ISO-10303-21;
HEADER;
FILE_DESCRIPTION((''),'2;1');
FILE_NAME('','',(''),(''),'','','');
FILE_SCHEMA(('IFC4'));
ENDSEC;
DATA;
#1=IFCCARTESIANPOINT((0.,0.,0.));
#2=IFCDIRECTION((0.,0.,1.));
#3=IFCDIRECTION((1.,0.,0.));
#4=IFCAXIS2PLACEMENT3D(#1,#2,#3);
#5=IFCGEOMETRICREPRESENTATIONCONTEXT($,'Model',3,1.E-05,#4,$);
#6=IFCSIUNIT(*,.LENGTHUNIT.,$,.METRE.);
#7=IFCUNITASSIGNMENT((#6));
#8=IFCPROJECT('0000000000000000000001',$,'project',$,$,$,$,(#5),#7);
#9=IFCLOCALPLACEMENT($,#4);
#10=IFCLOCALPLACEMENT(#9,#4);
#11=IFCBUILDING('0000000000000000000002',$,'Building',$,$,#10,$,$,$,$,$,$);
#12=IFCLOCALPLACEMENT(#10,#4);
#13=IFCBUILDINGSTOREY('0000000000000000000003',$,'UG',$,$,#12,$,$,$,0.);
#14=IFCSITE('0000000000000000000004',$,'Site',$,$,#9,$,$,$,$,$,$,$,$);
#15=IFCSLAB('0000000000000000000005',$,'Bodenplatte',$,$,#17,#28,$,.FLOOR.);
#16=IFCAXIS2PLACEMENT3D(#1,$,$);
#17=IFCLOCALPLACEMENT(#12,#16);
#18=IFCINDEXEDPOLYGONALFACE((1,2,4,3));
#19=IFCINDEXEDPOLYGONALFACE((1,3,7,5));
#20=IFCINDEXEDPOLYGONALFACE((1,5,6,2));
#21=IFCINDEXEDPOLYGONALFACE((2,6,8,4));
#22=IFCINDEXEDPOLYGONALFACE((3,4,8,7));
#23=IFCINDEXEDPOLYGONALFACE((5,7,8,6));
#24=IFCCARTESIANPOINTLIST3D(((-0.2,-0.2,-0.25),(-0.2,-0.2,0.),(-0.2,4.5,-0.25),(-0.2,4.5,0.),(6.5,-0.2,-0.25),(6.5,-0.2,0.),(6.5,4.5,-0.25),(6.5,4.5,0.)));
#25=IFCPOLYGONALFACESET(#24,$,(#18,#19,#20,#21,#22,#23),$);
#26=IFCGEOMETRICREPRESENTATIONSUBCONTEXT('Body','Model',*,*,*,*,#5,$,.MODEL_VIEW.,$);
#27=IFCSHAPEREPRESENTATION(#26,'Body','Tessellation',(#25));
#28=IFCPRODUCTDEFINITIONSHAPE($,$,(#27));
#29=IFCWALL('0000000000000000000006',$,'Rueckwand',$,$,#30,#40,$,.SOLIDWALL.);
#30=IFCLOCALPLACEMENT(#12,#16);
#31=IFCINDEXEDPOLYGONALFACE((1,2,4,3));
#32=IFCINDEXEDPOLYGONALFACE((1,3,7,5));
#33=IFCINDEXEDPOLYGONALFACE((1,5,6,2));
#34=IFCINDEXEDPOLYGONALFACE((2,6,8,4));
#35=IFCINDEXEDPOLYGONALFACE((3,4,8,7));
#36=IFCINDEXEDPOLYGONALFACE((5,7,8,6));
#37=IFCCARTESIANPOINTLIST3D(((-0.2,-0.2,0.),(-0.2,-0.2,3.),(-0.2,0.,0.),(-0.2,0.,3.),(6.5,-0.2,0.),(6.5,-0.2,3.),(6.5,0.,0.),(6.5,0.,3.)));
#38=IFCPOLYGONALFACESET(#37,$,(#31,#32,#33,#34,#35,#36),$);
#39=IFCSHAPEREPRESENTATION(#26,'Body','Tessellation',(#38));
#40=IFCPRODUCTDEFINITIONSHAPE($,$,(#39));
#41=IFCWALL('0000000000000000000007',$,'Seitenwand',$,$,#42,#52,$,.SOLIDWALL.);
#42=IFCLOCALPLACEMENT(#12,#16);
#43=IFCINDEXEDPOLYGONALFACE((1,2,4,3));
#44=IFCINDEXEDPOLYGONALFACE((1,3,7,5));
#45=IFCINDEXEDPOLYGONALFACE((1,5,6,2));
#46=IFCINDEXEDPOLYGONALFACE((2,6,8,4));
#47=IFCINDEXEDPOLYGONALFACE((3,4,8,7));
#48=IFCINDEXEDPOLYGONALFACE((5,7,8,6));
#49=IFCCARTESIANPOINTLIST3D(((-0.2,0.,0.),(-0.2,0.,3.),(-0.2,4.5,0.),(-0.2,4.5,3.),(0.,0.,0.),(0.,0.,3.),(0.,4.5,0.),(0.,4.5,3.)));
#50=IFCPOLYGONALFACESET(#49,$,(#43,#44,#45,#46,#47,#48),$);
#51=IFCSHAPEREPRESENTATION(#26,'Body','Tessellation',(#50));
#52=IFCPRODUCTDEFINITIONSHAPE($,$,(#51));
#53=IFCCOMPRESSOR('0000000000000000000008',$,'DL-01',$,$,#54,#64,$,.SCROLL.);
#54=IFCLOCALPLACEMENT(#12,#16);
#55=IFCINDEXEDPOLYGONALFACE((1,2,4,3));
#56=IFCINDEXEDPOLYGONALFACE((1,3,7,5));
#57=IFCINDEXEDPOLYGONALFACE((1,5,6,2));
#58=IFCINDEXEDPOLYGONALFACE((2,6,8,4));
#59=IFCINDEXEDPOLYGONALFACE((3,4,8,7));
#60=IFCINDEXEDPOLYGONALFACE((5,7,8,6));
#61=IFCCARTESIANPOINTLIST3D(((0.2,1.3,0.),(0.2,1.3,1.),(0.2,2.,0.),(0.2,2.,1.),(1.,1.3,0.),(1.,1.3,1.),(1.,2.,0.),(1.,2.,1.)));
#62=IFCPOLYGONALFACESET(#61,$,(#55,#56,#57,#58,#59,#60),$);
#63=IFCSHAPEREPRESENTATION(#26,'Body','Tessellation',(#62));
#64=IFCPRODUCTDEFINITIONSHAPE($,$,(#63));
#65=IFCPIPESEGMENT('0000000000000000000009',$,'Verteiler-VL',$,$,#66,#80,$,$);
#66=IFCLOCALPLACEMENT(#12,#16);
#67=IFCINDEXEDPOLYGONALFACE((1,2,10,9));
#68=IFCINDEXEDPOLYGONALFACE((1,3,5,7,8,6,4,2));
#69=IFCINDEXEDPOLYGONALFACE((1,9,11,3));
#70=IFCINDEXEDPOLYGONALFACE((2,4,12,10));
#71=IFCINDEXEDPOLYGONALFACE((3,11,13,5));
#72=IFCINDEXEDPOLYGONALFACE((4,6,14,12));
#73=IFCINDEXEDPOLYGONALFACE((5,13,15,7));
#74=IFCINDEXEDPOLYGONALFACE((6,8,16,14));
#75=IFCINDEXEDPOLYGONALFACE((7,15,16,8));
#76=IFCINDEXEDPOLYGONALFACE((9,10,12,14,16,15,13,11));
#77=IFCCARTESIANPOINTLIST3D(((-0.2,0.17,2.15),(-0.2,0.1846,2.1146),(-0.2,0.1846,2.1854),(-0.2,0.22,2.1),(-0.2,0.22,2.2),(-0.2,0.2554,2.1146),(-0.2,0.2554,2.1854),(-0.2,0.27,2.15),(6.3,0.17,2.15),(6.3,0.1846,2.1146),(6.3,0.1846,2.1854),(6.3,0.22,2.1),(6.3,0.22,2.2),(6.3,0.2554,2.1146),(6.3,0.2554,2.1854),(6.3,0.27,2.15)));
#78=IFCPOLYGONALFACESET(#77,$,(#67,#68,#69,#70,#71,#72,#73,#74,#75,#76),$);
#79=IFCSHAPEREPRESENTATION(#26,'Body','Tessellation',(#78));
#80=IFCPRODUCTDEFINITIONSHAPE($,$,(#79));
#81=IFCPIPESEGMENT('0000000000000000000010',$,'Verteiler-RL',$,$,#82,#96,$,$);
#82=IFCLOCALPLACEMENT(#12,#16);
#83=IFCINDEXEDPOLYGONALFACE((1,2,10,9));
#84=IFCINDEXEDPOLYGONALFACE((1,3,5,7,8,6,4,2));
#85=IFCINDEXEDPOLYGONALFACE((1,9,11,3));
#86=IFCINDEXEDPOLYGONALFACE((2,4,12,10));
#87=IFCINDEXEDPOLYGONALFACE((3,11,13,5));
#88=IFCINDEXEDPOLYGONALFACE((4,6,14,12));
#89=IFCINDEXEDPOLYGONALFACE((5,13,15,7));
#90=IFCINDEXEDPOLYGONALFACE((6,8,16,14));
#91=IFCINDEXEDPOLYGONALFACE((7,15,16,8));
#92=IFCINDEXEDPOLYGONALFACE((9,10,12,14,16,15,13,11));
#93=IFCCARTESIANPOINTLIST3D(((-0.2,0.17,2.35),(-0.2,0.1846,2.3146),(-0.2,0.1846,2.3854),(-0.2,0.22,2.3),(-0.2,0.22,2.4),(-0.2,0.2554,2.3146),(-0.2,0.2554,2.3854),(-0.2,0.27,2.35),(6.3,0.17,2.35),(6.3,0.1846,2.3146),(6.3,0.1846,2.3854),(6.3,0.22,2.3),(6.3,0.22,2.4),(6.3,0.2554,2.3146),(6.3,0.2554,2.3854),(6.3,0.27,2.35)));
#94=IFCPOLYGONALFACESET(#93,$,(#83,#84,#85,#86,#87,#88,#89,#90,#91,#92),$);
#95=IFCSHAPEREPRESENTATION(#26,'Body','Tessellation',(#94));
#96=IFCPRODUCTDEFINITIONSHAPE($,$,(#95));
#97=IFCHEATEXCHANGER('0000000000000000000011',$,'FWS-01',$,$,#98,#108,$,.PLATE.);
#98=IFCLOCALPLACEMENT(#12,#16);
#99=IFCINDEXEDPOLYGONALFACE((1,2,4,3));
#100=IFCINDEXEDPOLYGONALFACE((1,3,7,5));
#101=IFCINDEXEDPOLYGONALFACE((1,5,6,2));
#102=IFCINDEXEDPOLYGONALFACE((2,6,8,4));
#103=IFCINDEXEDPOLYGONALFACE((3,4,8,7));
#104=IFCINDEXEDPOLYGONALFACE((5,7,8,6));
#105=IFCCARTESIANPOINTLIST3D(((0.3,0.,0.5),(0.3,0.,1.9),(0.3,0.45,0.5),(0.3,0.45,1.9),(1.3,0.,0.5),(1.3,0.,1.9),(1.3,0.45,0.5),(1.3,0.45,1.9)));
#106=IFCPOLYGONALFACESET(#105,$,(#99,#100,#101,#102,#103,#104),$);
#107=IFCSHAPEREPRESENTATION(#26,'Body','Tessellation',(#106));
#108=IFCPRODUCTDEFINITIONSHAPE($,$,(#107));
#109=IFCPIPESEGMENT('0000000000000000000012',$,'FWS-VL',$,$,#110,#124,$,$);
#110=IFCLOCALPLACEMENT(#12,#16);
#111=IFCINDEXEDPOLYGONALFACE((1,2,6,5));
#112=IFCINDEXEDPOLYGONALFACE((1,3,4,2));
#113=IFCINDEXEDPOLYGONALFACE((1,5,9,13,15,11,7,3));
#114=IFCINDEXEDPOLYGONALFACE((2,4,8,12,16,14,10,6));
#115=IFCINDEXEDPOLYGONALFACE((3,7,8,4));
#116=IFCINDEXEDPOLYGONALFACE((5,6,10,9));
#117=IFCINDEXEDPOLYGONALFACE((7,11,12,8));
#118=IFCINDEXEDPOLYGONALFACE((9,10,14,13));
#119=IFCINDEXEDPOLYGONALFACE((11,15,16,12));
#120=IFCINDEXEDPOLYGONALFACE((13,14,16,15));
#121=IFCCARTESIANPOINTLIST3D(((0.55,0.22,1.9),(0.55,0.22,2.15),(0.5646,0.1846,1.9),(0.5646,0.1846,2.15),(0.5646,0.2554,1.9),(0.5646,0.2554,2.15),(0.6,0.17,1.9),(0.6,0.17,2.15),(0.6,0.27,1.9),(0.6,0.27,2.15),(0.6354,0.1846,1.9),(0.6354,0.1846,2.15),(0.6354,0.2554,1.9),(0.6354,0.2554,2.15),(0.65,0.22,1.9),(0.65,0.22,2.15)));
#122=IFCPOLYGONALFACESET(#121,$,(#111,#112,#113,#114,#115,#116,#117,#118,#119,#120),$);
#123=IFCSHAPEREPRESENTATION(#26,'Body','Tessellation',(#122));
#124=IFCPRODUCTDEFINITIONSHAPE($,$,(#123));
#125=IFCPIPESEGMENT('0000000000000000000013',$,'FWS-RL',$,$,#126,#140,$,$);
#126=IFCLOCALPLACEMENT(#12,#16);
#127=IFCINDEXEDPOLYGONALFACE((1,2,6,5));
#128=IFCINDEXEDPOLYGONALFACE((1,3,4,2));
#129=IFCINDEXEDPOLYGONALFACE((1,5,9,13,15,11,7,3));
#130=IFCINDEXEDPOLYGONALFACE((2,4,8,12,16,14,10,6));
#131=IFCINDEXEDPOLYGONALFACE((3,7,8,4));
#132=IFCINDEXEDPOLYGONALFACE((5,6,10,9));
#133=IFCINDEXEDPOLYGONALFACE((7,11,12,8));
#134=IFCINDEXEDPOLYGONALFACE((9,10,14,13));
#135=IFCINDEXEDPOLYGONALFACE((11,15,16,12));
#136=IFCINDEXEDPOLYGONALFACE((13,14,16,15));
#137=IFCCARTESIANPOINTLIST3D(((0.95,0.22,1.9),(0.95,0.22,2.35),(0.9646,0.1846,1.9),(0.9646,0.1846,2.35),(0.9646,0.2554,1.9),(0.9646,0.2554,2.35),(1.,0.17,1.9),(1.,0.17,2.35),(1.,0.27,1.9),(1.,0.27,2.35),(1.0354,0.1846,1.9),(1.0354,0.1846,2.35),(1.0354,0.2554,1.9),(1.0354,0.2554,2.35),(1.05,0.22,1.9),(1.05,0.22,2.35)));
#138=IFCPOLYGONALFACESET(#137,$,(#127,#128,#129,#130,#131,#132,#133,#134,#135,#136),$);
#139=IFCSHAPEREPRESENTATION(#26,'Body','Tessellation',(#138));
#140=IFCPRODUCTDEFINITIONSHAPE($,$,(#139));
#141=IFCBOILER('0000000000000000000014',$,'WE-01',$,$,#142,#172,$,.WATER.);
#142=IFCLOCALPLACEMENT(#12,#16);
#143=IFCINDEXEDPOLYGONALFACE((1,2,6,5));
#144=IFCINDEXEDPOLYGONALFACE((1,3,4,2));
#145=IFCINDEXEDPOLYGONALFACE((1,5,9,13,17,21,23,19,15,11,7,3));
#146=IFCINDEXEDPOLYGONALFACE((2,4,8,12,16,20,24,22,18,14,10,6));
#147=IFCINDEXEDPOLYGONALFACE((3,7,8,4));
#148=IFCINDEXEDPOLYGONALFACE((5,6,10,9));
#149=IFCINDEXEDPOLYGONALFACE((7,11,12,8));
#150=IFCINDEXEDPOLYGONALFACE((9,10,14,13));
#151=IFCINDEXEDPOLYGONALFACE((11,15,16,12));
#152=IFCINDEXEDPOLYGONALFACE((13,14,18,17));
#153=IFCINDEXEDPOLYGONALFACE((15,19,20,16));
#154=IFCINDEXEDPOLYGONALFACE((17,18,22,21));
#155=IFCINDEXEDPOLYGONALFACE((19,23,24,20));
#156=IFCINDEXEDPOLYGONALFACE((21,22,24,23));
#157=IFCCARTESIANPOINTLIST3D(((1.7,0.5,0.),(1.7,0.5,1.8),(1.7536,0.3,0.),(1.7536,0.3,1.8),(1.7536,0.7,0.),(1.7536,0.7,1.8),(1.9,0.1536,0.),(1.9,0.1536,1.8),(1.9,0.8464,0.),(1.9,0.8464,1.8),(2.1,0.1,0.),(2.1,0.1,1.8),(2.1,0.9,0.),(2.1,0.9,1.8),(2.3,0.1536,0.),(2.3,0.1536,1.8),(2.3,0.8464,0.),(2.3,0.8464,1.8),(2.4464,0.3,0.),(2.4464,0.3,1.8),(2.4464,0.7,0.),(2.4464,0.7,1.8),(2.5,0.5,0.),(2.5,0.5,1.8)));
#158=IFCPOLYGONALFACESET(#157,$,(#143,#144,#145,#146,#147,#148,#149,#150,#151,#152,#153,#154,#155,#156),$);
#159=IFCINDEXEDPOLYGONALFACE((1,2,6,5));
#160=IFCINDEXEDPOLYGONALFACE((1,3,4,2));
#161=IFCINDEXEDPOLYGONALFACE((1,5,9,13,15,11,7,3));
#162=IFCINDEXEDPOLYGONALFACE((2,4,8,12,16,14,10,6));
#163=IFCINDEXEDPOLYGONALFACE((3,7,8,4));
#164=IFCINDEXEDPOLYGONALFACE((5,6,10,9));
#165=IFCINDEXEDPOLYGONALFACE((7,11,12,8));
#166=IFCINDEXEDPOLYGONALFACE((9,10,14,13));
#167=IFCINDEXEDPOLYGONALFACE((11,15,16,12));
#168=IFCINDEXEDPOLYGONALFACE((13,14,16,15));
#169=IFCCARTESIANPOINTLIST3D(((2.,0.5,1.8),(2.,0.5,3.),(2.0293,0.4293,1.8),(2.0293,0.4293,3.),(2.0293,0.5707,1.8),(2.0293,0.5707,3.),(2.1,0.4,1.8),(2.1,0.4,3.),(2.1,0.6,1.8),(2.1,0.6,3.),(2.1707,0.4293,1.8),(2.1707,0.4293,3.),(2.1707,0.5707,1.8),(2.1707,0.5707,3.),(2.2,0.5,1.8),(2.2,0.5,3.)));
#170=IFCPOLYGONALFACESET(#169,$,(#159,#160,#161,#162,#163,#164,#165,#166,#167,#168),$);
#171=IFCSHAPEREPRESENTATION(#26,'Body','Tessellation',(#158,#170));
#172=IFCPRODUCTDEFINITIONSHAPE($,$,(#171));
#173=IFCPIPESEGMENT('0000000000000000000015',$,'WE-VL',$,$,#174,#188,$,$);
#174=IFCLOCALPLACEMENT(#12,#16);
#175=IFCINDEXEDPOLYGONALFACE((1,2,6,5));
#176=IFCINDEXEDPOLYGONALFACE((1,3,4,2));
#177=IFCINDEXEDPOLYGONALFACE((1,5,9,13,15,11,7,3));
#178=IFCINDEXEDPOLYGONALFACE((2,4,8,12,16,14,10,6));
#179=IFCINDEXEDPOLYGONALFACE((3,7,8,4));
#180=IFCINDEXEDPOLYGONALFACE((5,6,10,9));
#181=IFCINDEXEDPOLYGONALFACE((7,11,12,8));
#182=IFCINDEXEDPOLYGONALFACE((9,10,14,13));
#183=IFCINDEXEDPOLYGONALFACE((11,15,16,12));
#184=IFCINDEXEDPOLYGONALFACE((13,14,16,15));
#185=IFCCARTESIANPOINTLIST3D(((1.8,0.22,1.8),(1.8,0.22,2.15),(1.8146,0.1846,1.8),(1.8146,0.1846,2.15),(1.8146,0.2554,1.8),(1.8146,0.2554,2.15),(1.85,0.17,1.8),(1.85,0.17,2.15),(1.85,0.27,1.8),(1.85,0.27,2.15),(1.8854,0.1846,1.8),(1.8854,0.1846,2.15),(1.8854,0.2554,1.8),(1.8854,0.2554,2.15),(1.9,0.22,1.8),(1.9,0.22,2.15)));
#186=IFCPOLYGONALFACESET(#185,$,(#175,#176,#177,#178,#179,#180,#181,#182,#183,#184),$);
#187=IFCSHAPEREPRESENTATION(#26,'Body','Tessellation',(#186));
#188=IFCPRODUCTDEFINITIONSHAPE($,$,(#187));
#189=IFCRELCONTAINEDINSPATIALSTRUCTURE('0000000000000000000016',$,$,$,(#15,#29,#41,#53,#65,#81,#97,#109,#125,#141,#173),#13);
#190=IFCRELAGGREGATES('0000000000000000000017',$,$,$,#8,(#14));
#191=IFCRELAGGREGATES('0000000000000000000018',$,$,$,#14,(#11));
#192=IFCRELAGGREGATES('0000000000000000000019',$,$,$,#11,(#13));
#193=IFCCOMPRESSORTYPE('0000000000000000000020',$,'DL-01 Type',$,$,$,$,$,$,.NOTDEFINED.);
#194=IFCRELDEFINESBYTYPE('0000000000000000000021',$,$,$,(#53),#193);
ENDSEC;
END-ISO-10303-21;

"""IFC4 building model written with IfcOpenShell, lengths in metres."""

from ifc_helpers import new_model, si_unit, frame, origin_with_axes, place, context, subcontext, project, spatial, polyline, outline, extrude, type_object, element, save


model = new_model("IFC4")

# Units and contexts
model_context = context("Model", 3, precision=1e-05, world=origin_with_axes())
body_context = subcontext(model_context, "Body", "Model", "MODEL_VIEW")
ifc_project = project(units=[si_unit("LENGTHUNIT", "METRE")], contexts=[model_context])

# Site, building, storey
site_placement = place(None, origin_with_axes())
site = spatial("IfcSite", under=ifc_project, at=site_placement, Name="Site")
building_placement = place(site_placement, origin_with_axes())
building = spatial("IfcBuilding", under=site, at=building_placement, Name="Building")
storey_placement = place(building_placement, origin_with_axes())
storey = spatial("IfcBuildingStorey", under=building, at=storey_placement, Name="UG", Elevation=0.0)

# Slab
slab_placement = place(storey_placement, frame((0.0, 0.0, -0.25), z_axis=(0.0, 0.0, 1.0), x_axis=(1.0, 0.0, 0.0)))
element("IfcSlab", 1, at=slab_placement, inside=storey, Name="Bodenplatte", PredefinedType="FLOOR", context=body_context, shape_type="SweptSolid", body=[
    extrude(outline(polyline([(-0.2, -0.2, 0.0), (6.5, -0.2, 0.0), (6.5, 4.5, 0.0), (-0.2, 4.5, 0.0), (-0.2, -0.2, 0.0)])), origin_with_axes(), (0.0, 0.0, 1.0), 0.25),
])

# Walls
wall_1_placement = place(storey_placement, frame((-0.2, -0.2, 0.0), z_axis=(0.0, 0.0, 1.0), x_axis=(1.0, 0.0, 0.0)))
element("IfcWall", 2, at=wall_1_placement, inside=storey, Name="Rueckwand", PredefinedType="SOLIDWALL", context=body_context, shape_type="SweptSolid", body=[
    extrude(outline(polyline([(0.0, 0.0, 0.0), (6.7, 0.0, 0.0), (6.7, 0.2, 0.0), (0.0, 0.2, 0.0), (0.0, 0.0, 0.0)])), origin_with_axes(), (0.0, 0.0, 1.0), 3.0),
])
wall_2_placement = place(storey_placement, frame((0.0, 0.0, 0.0), z_axis=(0.0, 0.0, 1.0), x_axis=(0.0, 1.0, 0.0)))
element("IfcWall", 3, at=wall_2_placement, inside=storey, Name="Seitenwand", PredefinedType="SOLIDWALL", context=body_context, shape_type="SweptSolid", body=[
    extrude(outline(polyline([(0.0, 0.0, 0.0), (4.5, 0.0, 0.0), (4.5, 0.2, 0.0), (0.0, 0.2, 0.0), (0.0, 0.0, 0.0)])), origin_with_axes(), (0.0, 0.0, 1.0), 3.0),
])

# Compressor
compressor_type = type_object("IfcCompressorType", Name="DL-01 Type", PredefinedType="NOTDEFINED")
compressor_placement = place(storey_placement, origin_with_axes())
element("IfcCompressor", 4, at=compressor_placement, inside=storey, type_object=compressor_type, Name="DL-01", PredefinedType="SCROLL", context=body_context, shape_type="SweptSolid", body=[
    extrude(outline(polyline([(0.2, 1.3, 0.0), (1.0, 1.3, 0.0), (1.0, 2.0, 0.0), (0.2, 2.0, 0.0), (0.2, 1.3, 0.0)])), origin_with_axes(), (0.0, 0.0, 1.0), 1.0),
])

# Pipe segments
pipe_segment_1_placement = place(storey_placement, origin_with_axes())
element("IfcPipeSegment", 5, at=pipe_segment_1_placement, inside=storey, Name="Verteiler-VL", context=body_context, shape_type="SweptSolid", body=[
    extrude(outline(polyline([(0.05, 0.0, 0.0), (0.0354, 0.0354, 0.0), (0.0, 0.05, 0.0), (-0.0354, 0.0354, 0.0), (-0.05, 0.0, 0.0), (-0.0354, -0.0354, 0.0), (0.0, -0.05, 0.0), (0.0354, -0.0354, 0.0), (0.05, 0.0, 0.0)])), frame((-0.2, 0.22, 2.15), z_axis=(1.0, 0.0, 0.0), x_axis=(0.0, 1.0, 0.0)), (0.0, 0.0, 1.0), 6.5),
])
pipe_segment_2_placement = place(storey_placement, origin_with_axes())
element("IfcPipeSegment", 6, at=pipe_segment_2_placement, inside=storey, Name="Verteiler-RL", context=body_context, shape_type="SweptSolid", body=[
    extrude(outline(polyline([(0.05, 0.0, 0.0), (0.0354, 0.0354, 0.0), (0.0, 0.05, 0.0), (-0.0354, 0.0354, 0.0), (-0.05, 0.0, 0.0), (-0.0354, -0.0354, 0.0), (0.0, -0.05, 0.0), (0.0354, -0.0354, 0.0), (0.05, 0.0, 0.0)])), frame((-0.2, 0.22, 2.35), z_axis=(1.0, 0.0, 0.0), x_axis=(0.0, 1.0, 0.0)), (0.0, 0.0, 1.0), 6.5),
])

# Heat exchanger
heat_exchanger_placement = place(storey_placement, origin_with_axes())
element("IfcHeatExchanger", 7, at=heat_exchanger_placement, inside=storey, Name="FWS-01", PredefinedType="PLATE", context=body_context, shape_type="SweptSolid", body=[
    extrude(outline(polyline([(0.3, 0.0, 0.0), (1.3, 0.0, 0.0), (1.3, 0.45, 0.0), (0.3, 0.45, 0.0), (0.3, 0.0, 0.0)])), frame((0.0, 0.0, 0.5), z_axis=(0.0, 0.0, 1.0), x_axis=(1.0, 0.0, 0.0)), (0.0, 0.0, 1.0), 1.4),
])

# Pipe segments
pipe_segment_3_placement = place(storey_placement, origin_with_axes())
element("IfcPipeSegment", 8, at=pipe_segment_3_placement, inside=storey, Name="FWS-VL", context=body_context, shape_type="SweptSolid", body=[
    extrude(outline(polyline([(0.05, 0.0, 0.0), (0.0354, 0.0354, 0.0), (0.0, 0.05, 0.0), (-0.0354, 0.0354, 0.0), (-0.05, 0.0, 0.0), (-0.0354, -0.0354, 0.0), (0.0, -0.05, 0.0), (0.0354, -0.0354, 0.0), (0.05, 0.0, 0.0)])), frame((0.6, 0.22, 1.9), z_axis=(0.0, 0.0, 1.0), x_axis=(1.0, 0.0, 0.0)), (0.0, 0.0, 1.0), 0.25),
])
pipe_segment_4_placement = place(storey_placement, origin_with_axes())
element("IfcPipeSegment", 9, at=pipe_segment_4_placement, inside=storey, Name="FWS-RL", context=body_context, shape_type="SweptSolid", body=[
    extrude(outline(polyline([(0.05, 0.0, 0.0), (0.0354, 0.0354, 0.0), (0.0, 0.05, 0.0), (-0.0354, 0.0354, 0.0), (-0.05, 0.0, 0.0), (-0.0354, -0.0354, 0.0), (0.0, -0.05, 0.0), (0.0354, -0.0354, 0.0), (0.05, 0.0, 0.0)])), frame((1.0, 0.22, 1.9), z_axis=(0.0, 0.0, 1.0), x_axis=(1.0, 0.0, 0.0)), (0.0, 0.0, 1.0), 0.45),
])

# Boiler
boiler_placement = place(storey_placement, origin_with_axes())
element("IfcBoiler", 10, at=boiler_placement, inside=storey, Name="WE-01", PredefinedType="WATER", context=body_context, shape_type="SweptSolid", body=[
    extrude(outline(polyline([(0.4, 0.0, 0.0), (0.3464, 0.2, 0.0), (0.2, 0.3464, 0.0), (0.0, 0.4, 0.0), (-0.2, 0.3464, 0.0), (-0.3464, 0.2, 0.0), (-0.4, 0.0, 0.0), (-0.3464, -0.2, 0.0), (-0.2, -0.3464, 0.0), (0.0, -0.4, 0.0), (0.2, -0.3464, 0.0), (0.3464, -0.2, 0.0), (0.4, 0.0, 0.0)])), frame((2.1, 0.5, 0.0), z_axis=(0.0, 0.0, 1.0), x_axis=(1.0, 0.0, 0.0)), (0.0, 0.0, 1.0), 1.8),
    extrude(outline(polyline([(0.1, 0.0, 0.0), (0.0707, 0.0707, 0.0), (0.0, 0.1, 0.0), (-0.0707, 0.0707, 0.0), (-0.1, 0.0, 0.0), (-0.0707, -0.0707, 0.0), (0.0, -0.1, 0.0), (0.0707, -0.0707, 0.0), (0.1, 0.0, 0.0)])), frame((2.1, 0.5, 1.8), z_axis=(0.0, 0.0, 1.0), x_axis=(1.0, 0.0, 0.0)), (0.0, 0.0, 1.0), 1.2),
])

# Pipe segment
pipe_segment_5_placement = place(storey_placement, origin_with_axes())
element("IfcPipeSegment", 11, at=pipe_segment_5_placement, inside=storey, Name="WE-VL", context=body_context, shape_type="SweptSolid", body=[
    extrude(outline(polyline([(0.05, 0.0, 0.0), (0.0354, 0.0354, 0.0), (0.0, 0.05, 0.0), (-0.0354, 0.0354, 0.0), (-0.05, 0.0, 0.0), (-0.0354, -0.0354, 0.0), (0.0, -0.05, 0.0), (0.0354, -0.0354, 0.0), (0.05, 0.0, 0.0)])), frame((1.85, 0.22, 1.8), z_axis=(0.0, 0.0, 1.0), x_axis=(1.0, 0.0, 0.0)), (0.0, 0.0, 1.0), 0.35),
])

save(model, "model.ifc")
